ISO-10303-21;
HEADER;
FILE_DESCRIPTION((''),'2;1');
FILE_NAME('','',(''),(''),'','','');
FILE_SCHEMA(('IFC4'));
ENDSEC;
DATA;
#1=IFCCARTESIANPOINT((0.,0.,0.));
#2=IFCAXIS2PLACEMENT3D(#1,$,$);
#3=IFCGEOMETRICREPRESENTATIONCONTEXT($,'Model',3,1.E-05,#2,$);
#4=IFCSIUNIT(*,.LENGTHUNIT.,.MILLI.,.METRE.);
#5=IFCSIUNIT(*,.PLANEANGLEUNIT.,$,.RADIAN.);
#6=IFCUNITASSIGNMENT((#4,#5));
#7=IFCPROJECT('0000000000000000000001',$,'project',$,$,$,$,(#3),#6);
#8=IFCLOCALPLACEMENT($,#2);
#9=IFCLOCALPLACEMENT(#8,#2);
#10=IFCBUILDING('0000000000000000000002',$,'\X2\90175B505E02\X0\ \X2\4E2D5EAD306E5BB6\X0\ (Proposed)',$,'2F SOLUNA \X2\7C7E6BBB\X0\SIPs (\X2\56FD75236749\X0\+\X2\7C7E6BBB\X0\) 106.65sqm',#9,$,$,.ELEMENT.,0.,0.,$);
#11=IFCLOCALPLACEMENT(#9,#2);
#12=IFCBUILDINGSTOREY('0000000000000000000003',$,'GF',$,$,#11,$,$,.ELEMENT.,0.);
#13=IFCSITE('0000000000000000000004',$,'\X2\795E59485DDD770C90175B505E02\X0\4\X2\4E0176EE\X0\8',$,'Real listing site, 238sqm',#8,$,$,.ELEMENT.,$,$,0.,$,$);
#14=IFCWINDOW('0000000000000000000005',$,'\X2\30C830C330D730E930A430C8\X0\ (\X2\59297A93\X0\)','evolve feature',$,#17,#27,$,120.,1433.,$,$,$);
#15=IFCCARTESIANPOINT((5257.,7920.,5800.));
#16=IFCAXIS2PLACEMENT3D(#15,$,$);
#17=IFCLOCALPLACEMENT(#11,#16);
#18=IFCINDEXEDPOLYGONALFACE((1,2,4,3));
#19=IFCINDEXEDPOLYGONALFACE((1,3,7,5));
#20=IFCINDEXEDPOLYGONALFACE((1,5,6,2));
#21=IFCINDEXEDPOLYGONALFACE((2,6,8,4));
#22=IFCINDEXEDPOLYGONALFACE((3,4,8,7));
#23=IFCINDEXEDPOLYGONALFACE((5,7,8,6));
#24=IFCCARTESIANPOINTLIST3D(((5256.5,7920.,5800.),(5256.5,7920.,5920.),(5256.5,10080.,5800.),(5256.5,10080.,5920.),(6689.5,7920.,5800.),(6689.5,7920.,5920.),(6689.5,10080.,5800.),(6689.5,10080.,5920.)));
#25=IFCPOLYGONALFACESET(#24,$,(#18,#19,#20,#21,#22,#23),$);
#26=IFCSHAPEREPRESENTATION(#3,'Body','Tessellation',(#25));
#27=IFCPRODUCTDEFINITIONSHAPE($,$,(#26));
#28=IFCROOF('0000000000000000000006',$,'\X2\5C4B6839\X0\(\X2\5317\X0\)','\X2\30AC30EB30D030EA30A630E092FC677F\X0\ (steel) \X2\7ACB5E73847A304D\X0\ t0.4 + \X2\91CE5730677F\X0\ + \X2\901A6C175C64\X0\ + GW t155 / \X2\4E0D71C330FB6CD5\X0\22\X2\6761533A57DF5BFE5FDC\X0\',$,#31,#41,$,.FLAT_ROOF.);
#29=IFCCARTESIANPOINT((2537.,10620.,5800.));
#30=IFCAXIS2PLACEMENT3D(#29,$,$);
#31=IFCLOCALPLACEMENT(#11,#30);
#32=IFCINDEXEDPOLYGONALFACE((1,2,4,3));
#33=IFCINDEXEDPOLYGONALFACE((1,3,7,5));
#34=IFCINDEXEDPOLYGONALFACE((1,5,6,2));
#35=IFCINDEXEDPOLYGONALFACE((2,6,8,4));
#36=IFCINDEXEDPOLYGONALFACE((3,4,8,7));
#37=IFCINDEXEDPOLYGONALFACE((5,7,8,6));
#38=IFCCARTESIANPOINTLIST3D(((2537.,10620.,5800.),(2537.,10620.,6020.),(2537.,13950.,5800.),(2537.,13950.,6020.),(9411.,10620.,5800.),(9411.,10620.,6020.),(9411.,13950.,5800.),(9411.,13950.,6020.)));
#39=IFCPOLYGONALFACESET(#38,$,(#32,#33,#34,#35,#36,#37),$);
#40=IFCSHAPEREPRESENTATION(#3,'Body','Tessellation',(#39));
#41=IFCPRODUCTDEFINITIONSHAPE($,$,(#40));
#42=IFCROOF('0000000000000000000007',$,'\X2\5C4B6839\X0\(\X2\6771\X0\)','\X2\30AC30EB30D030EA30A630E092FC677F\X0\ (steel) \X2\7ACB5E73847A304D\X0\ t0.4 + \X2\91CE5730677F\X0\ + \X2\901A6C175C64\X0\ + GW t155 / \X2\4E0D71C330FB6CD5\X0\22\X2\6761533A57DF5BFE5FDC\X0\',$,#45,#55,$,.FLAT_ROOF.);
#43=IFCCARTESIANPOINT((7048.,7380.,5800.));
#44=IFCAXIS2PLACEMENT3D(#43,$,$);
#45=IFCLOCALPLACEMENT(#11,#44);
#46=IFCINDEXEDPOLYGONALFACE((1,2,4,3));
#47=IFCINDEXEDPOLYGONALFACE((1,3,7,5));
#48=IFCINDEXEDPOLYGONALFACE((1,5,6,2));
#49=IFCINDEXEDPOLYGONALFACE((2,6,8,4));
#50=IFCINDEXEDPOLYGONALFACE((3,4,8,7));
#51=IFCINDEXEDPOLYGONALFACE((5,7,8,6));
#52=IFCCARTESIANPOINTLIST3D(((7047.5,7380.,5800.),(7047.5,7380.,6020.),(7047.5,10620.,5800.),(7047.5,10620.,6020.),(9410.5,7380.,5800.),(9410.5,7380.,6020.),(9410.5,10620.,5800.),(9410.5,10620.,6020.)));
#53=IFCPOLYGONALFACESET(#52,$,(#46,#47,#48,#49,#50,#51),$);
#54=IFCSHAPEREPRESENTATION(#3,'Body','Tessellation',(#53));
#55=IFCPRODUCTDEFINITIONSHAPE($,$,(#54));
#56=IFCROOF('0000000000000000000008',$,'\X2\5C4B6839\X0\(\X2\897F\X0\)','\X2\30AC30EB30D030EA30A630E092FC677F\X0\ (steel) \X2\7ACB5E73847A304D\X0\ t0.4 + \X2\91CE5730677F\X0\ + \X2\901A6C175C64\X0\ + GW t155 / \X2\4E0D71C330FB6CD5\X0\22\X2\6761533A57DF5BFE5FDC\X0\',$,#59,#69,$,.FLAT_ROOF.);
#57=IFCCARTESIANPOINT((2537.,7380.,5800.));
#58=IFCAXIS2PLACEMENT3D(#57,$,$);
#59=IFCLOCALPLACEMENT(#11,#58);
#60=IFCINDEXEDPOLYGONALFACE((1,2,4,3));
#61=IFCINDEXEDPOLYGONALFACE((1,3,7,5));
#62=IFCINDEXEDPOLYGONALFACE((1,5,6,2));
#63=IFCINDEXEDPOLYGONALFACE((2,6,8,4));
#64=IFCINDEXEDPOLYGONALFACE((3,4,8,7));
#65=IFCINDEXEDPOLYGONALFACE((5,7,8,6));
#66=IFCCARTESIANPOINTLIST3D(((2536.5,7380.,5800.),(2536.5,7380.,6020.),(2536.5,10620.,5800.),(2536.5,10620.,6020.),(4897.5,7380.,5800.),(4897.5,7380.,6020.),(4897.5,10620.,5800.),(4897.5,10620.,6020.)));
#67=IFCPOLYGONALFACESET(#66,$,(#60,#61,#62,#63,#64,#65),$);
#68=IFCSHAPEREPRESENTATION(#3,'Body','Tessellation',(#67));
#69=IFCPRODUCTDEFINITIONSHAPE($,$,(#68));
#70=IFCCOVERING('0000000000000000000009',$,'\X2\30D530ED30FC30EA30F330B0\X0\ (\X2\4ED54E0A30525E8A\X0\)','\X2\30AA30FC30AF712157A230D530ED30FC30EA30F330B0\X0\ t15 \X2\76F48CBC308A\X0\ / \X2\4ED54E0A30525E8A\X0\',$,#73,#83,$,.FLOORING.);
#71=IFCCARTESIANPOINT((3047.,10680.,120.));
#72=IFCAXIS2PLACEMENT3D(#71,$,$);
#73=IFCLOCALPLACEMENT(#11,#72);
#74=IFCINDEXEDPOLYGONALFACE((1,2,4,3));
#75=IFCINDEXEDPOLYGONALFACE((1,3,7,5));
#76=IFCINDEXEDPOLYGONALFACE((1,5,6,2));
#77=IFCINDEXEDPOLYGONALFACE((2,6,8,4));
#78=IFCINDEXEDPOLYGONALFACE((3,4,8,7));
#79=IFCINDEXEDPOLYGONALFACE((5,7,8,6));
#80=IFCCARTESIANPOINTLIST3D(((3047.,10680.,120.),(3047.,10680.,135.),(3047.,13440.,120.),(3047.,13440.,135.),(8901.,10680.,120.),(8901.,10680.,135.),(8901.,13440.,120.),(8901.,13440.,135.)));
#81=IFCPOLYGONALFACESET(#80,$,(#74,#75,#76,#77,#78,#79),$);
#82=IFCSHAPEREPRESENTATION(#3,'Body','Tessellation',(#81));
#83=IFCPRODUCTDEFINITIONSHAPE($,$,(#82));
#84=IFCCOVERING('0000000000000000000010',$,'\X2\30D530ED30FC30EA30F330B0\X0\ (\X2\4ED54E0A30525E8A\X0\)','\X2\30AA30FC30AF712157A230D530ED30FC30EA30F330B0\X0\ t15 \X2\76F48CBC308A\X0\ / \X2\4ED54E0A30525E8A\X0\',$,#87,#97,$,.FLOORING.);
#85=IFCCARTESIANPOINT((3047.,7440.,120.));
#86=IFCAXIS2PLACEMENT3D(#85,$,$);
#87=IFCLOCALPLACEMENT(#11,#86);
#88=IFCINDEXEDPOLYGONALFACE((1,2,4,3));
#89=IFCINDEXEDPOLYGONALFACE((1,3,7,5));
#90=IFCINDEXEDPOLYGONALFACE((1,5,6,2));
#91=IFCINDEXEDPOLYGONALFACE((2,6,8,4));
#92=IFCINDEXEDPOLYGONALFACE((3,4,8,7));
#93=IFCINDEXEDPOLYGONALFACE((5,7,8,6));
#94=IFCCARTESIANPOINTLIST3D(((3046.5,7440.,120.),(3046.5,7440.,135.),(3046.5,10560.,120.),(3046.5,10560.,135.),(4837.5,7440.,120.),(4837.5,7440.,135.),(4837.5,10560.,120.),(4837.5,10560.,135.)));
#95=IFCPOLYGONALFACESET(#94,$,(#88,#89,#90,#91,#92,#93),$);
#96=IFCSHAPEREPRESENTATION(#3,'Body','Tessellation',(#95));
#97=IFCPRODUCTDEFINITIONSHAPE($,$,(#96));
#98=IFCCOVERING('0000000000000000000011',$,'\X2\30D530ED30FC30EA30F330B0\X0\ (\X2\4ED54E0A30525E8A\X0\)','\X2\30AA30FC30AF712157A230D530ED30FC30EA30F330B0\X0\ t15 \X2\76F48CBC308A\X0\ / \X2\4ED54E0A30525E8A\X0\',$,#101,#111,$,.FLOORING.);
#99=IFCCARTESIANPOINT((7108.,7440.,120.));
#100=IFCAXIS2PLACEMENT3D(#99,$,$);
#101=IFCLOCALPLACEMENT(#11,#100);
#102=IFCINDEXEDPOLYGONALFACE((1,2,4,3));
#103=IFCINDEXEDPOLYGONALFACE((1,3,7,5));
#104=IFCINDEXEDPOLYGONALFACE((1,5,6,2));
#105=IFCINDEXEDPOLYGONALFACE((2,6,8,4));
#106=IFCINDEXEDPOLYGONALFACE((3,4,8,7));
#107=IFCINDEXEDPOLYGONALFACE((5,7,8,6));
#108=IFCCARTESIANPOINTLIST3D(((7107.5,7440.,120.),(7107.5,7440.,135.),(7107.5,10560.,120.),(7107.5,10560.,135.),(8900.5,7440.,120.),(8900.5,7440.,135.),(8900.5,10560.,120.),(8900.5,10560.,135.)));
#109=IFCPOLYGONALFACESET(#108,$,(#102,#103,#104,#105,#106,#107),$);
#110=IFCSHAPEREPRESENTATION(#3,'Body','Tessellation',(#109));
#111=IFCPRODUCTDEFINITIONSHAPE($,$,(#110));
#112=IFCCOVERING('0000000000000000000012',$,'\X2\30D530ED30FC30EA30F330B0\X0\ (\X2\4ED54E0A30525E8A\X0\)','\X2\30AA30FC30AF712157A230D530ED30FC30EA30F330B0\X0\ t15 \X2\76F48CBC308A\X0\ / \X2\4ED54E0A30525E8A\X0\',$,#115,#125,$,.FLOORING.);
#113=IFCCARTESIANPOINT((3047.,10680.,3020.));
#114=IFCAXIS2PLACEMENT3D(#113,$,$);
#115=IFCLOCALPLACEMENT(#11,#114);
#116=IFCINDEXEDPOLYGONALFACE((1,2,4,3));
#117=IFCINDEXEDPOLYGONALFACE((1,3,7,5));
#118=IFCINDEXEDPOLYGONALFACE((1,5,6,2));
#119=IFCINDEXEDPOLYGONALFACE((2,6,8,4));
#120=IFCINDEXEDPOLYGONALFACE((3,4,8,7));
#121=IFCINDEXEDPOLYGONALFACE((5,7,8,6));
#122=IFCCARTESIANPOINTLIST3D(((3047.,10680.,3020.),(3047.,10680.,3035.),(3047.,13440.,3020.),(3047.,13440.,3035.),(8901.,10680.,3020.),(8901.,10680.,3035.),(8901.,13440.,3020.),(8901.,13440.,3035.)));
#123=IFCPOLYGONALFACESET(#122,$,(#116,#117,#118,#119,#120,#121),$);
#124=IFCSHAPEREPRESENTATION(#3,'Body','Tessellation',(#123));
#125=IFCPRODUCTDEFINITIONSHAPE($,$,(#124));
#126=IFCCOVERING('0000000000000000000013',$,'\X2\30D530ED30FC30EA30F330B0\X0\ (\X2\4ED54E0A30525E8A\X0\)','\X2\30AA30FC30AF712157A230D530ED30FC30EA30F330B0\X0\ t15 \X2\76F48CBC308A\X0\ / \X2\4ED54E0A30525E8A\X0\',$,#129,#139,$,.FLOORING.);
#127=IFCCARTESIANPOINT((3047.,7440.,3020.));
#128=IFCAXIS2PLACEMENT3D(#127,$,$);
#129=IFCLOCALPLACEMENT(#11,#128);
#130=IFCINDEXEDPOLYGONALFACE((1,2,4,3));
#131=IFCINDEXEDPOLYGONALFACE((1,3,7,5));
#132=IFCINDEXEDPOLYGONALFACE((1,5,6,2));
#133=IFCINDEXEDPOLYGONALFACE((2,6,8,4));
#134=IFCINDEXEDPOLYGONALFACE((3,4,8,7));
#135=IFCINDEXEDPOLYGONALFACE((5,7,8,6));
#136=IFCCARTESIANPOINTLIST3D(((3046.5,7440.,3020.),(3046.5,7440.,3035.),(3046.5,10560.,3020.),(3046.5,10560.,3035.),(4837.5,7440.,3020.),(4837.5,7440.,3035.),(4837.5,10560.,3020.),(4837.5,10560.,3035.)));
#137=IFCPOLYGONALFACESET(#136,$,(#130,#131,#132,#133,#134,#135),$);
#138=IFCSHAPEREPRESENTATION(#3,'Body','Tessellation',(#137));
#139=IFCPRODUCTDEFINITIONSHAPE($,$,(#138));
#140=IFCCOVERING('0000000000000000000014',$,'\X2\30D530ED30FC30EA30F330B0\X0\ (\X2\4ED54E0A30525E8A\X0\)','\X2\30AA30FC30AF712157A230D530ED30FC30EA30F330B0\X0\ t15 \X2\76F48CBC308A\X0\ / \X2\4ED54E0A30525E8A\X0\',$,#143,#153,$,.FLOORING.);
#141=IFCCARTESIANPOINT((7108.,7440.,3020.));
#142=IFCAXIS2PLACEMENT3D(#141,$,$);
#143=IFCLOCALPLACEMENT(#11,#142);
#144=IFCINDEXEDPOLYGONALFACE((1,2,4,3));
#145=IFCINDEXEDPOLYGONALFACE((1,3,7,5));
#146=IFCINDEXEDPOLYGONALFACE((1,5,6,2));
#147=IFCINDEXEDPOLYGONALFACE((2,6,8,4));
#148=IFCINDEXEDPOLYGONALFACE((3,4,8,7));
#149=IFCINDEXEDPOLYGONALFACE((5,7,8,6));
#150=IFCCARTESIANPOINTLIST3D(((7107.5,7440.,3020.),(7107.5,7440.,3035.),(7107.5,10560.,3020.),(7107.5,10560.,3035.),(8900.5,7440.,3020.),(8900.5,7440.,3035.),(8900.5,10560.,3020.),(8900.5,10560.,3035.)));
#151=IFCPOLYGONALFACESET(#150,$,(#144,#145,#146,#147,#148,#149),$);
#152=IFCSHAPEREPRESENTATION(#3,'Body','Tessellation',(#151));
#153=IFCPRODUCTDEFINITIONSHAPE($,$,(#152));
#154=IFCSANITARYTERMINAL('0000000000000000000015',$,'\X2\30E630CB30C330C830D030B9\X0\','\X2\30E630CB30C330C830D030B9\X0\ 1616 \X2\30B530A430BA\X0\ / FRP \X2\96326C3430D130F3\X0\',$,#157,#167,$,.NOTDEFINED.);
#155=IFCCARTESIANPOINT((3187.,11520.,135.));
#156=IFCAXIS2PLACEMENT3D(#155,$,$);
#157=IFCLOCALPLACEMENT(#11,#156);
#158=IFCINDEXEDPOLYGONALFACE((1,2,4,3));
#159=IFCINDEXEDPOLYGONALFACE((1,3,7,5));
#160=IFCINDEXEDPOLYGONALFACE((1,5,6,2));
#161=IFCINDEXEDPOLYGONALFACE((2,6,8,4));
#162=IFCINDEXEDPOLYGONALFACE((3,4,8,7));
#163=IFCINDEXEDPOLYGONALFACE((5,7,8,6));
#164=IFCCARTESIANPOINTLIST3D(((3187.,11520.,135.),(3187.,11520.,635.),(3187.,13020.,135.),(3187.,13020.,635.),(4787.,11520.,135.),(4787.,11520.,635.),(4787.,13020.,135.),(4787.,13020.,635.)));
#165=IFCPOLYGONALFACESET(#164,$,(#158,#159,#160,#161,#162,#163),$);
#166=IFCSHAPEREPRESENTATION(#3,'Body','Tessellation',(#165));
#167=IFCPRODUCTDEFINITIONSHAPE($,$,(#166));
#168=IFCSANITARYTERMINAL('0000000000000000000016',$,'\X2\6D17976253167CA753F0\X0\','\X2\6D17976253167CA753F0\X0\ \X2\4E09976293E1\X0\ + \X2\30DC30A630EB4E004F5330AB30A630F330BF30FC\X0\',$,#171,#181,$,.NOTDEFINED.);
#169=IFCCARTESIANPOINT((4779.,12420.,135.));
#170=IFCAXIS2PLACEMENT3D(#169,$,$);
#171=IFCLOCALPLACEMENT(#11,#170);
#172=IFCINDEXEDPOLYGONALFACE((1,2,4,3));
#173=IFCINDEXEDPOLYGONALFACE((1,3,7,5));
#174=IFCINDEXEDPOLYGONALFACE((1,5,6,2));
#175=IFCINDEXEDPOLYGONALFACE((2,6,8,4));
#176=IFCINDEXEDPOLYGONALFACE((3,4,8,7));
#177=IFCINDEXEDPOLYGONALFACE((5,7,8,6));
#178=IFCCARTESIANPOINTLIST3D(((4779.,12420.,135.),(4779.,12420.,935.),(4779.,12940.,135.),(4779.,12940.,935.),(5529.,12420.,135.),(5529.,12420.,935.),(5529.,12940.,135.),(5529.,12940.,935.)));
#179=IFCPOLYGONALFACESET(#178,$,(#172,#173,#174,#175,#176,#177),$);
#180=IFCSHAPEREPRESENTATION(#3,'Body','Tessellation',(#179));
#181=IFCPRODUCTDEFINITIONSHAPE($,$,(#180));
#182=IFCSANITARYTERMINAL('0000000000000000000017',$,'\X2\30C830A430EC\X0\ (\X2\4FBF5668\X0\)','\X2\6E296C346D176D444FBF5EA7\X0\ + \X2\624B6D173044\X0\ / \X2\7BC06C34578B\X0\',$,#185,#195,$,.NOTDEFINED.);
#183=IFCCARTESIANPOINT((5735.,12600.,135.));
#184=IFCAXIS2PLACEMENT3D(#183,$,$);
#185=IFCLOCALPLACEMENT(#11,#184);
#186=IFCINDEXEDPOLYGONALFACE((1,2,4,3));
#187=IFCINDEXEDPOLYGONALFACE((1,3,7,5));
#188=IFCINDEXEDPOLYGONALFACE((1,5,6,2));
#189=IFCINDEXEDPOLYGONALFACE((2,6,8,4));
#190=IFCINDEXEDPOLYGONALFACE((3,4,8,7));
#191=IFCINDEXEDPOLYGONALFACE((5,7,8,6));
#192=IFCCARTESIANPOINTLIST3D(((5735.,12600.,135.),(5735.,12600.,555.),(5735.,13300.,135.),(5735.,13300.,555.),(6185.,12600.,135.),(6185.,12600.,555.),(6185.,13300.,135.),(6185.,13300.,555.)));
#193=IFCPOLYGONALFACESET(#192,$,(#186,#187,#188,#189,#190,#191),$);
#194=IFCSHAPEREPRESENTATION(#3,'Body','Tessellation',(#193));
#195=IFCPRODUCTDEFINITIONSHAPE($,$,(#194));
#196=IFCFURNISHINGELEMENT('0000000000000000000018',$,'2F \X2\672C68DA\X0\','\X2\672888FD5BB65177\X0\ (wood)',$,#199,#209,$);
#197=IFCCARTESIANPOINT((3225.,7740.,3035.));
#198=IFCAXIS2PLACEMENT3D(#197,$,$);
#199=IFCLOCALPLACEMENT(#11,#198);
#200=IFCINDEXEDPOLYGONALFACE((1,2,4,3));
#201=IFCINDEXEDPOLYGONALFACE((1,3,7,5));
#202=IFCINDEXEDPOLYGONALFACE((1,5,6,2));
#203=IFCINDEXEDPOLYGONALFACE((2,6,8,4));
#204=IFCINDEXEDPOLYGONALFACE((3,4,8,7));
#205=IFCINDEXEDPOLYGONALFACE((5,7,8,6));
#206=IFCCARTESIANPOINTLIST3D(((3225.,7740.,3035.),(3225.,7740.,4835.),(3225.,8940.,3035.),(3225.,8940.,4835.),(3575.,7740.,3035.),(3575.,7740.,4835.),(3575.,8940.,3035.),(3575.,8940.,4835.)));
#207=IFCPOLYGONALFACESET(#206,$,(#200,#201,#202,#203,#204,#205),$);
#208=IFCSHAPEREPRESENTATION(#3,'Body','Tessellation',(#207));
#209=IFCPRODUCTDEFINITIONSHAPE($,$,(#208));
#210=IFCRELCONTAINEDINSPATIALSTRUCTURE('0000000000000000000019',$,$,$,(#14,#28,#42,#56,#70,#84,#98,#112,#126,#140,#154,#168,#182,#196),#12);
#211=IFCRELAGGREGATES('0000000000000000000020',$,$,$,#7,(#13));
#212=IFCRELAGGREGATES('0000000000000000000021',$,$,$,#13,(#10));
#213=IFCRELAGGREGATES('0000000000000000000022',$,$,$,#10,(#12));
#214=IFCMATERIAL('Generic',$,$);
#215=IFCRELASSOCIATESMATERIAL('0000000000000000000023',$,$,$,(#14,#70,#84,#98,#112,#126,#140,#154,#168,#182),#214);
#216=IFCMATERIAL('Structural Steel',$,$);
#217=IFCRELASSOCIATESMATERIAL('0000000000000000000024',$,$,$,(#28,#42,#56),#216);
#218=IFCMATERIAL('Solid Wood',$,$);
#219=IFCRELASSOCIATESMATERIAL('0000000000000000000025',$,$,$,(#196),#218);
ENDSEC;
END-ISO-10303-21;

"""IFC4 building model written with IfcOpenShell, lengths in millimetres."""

from ifc_helpers import new_model, si_unit, frame, frame_2d, origin, place, context, project, spatial, rectangle, extrude, material, element, save


model = new_model("IFC4")

# Units and contexts
model_context = context("Model", 3, precision=1e-05, world=origin())
ifc_project = project(units=[si_unit("LENGTHUNIT", "METRE", prefix="MILLI"), si_unit("PLANEANGLEUNIT", "RADIAN")], contexts=[model_context])

# Site, building, storey
site_placement = place(None, origin())
site = spatial("IfcSite", under=ifc_project, at=site_placement, Name="神奈川県逗子市4丁目8", ObjectType="Real listing site, 238sqm", CompositionType="ELEMENT", RefElevation=0.0)
building_placement = place(site_placement, origin())
building = spatial("IfcBuilding", under=site, at=building_placement, Name="逗子市 中庭の家 (Proposed)", ObjectType="2F SOLUNA 籾殻SIPs (国産杉+籾殻) 106.65sqm", CompositionType="ELEMENT", ElevationOfRefHeight=0.0, ElevationOfTerrain=0.0)
storey_placement = place(building_placement, origin())
storey = spatial("IfcBuildingStorey", under=building, at=storey_placement, Name="GF", CompositionType="ELEMENT", Elevation=0.0)

# Shared definitions
ifc_material_1 = material(Name="Solid Wood")

# Window
ifc_material_2 = material(Name="Generic")
window_1_placement = place(storey_placement, frame((5257.0, 7920.0, 5800.0)))
element("IfcWindow", 1, at=window_1_placement, inside=storey, material=ifc_material_2, Name="トップライト (天窓)", Description="evolve feature", OverallHeight=120.0, OverallWidth=1433.0, context=model_context, shape_type="SweptSolid", body=[
    extrude(rectangle(XDim=1433.0, YDim=2160.0, at=frame_2d((716.0, 1080.0))), frame((5257.0, 7920.0, 5800.0)), (0.0, 0.0, 1.0), 120.0),
])

# Roofs
ifc_material_3 = material(Name="Structural Steel")
roof_1_placement = place(storey_placement, frame((2537.0, 10620.0, 5800.0)))
element("IfcRoof", 2, at=roof_1_placement, inside=storey, material=ifc_material_3, Name="屋根(北)", Description="ガルバリウム鋼板 (steel) 立平葺き t0.4 + 野地板 + 通気層 + GW t155 / 不燃・法22条区域対応", PredefinedType="FLAT_ROOF", context=model_context, shape_type="SweptSolid", body=[
    extrude(rectangle(XDim=6874.0, YDim=3330.0, at=frame_2d((3437.0, 1665.0))), frame((2537.0, 10620.0, 5800.0)), (0.0, 0.0, 1.0), 220.0),
])
roof_2_placement = place(storey_placement, frame((7048.0, 7380.0, 5800.0)))
element("IfcRoof", 3, at=roof_2_placement, inside=storey, material=ifc_material_3, Name="屋根(東)", Description="ガルバリウム鋼板 (steel) 立平葺き t0.4 + 野地板 + 通気層 + GW t155 / 不燃・法22条区域対応", PredefinedType="FLAT_ROOF", context=model_context, shape_type="SweptSolid", body=[
    extrude(rectangle(XDim=2363.0, YDim=3240.0, at=frame_2d((1181.0, 1620.0))), frame((7048.0, 7380.0, 5800.0)), (0.0, 0.0, 1.0), 220.0),
])
roof_3_placement = place(storey_placement, frame((2537.0, 7380.0, 5800.0)))
element("IfcRoof", 4, at=roof_3_placement, inside=storey, material=ifc_material_3, Name="屋根(西)", Description="ガルバリウム鋼板 (steel) 立平葺き t0.4 + 野地板 + 通気層 + GW t155 / 不燃・法22条区域対応", PredefinedType="FLAT_ROOF", context=model_context, shape_type="SweptSolid", body=[
    extrude(rectangle(XDim=2361.0, YDim=3240.0, at=frame_2d((1180.0, 1620.0))), frame((2537.0, 7380.0, 5800.0)), (0.0, 0.0, 1.0), 220.0),
])

# Coverings
covering_1_placement = place(storey_placement, frame((3047.0, 10680.0, 120.0)))
element("IfcCovering", 5, at=covering_1_placement, inside=storey, material=ifc_material_2, Name="フローリング (仕上げ床)", Description="オーク無垢フローリング t15 直貼り / 仕上げ床", PredefinedType="FLOORING", context=model_context, shape_type="SweptSolid", body=[
    extrude(rectangle(XDim=5854.0, YDim=2760.0, at=frame_2d((2927.0, 1380.0))), frame((3047.0, 10680.0, 120.0)), (0.0, 0.0, 1.0), 15.0),
])
covering_2_placement = place(storey_placement, frame((3047.0, 7440.0, 120.0)))
element("IfcCovering", 6, at=covering_2_placement, inside=storey, material=ifc_material_2, Name="フローリング (仕上げ床)", Description="オーク無垢フローリング t15 直貼り / 仕上げ床", PredefinedType="FLOORING", context=model_context, shape_type="SweptSolid", body=[
    extrude(rectangle(XDim=1791.0, YDim=3120.0, at=frame_2d((895.0, 1560.0))), frame((3047.0, 7440.0, 120.0)), (0.0, 0.0, 1.0), 15.0),
])
covering_3_placement = place(storey_placement, frame((7108.0, 7440.0, 120.0)))
element("IfcCovering", 7, at=covering_3_placement, inside=storey, material=ifc_material_2, Name="フローリング (仕上げ床)", Description="オーク無垢フローリング t15 直貼り / 仕上げ床", PredefinedType="FLOORING", context=model_context, shape_type="SweptSolid", body=[
    extrude(rectangle(XDim=1793.0, YDim=3120.0, at=frame_2d((896.0, 1560.0))), frame((7108.0, 7440.0, 120.0)), (0.0, 0.0, 1.0), 15.0),
])
covering_4_placement = place(storey_placement, frame((3047.0, 10680.0, 3020.0)))
element("IfcCovering", 8, at=covering_4_placement, inside=storey, material=ifc_material_2, Name="フローリング (仕上げ床)", Description="オーク無垢フローリング t15 直貼り / 仕上げ床", PredefinedType="FLOORING", context=model_context, shape_type="SweptSolid", body=[
    extrude(rectangle(XDim=5854.0, YDim=2760.0, at=frame_2d((2927.0, 1380.0))), frame((3047.0, 10680.0, 3020.0)), (0.0, 0.0, 1.0), 15.0),
])
covering_5_placement = place(storey_placement, frame((3047.0, 7440.0, 3020.0)))
element("IfcCovering", 9, at=covering_5_placement, inside=storey, material=ifc_material_2, Name="フローリング (仕上げ床)", Description="オーク無垢フローリング t15 直貼り / 仕上げ床", PredefinedType="FLOORING", context=model_context, shape_type="SweptSolid", body=[
    extrude(rectangle(XDim=1791.0, YDim=3120.0, at=frame_2d((895.0, 1560.0))), frame((3047.0, 7440.0, 3020.0)), (0.0, 0.0, 1.0), 15.0),
])
covering_6_placement = place(storey_placement, frame((7108.0, 7440.0, 3020.0)))
element("IfcCovering", 10, at=covering_6_placement, inside=storey, material=ifc_material_2, Name="フローリング (仕上げ床)", Description="オーク無垢フローリング t15 直貼り / 仕上げ床", PredefinedType="FLOORING", context=model_context, shape_type="SweptSolid", body=[
    extrude(rectangle(XDim=1793.0, YDim=3120.0, at=frame_2d((896.0, 1560.0))), frame((7108.0, 7440.0, 3020.0)), (0.0, 0.0, 1.0), 15.0),
])

# Sanitary terminals
sanitary_terminal_1_placement = place(storey_placement, frame((3187.0, 11520.0, 135.0)))
element("IfcSanitaryTerminal", 11, at=sanitary_terminal_1_placement, inside=storey, material=ifc_material_2, Name="ユニットバス", Description="ユニットバス 1616 サイズ / FRP 防水パン", PredefinedType="NOTDEFINED", context=model_context, shape_type="SweptSolid", body=[
    extrude(rectangle(XDim=1600.0, YDim=1500.0, at=frame_2d((800.0, 750.0))), frame((3187.0, 11520.0, 135.0)), (0.0, 0.0, 1.0), 500.0),
])
sanitary_terminal_2_placement = place(storey_placement, frame((4779.0, 12420.0, 135.0)))
element("IfcSanitaryTerminal", 12, at=sanitary_terminal_2_placement, inside=storey, material=ifc_material_2, Name="洗面化粧台", Description="洗面化粧台 三面鏡 + ボウル一体カウンター", PredefinedType="NOTDEFINED", context=model_context, shape_type="SweptSolid", body=[
    extrude(rectangle(XDim=750.0, YDim=520.0, at=frame_2d((375.0, 260.0))), frame((4779.0, 12420.0, 135.0)), (0.0, 0.0, 1.0), 800.0),
])
sanitary_terminal_3_placement = place(storey_placement, frame((5735.0, 12600.0, 135.0)))
element("IfcSanitaryTerminal", 13, at=sanitary_terminal_3_placement, inside=storey, material=ifc_material_2, Name="トイレ (便器)", Description="温水洗浄便座 + 手洗い / 節水型", PredefinedType="NOTDEFINED", context=model_context, shape_type="SweptSolid", body=[
    extrude(rectangle(XDim=450.0, YDim=700.0, at=frame_2d((225.0, 350.0))), frame((5735.0, 12600.0, 135.0)), (0.0, 0.0, 1.0), 420.0),
])

# Furnishing element
furnishing_placement = place(storey_placement, frame((3225.0, 7740.0, 3035.0)))
element("IfcFurnishingElement", 14, at=furnishing_placement, inside=storey, material=ifc_material_1, Name="2F 本棚", Description="木製家具 (wood)", context=model_context, shape_type="SweptSolid", body=[
    extrude(rectangle(XDim=350.0, YDim=1200.0, at=frame_2d((175.0, 600.0))), frame((3225.0, 7740.0, 3035.0)), (0.0, 0.0, 1.0), 1800.0),
])

save(model, "model.ifc")
